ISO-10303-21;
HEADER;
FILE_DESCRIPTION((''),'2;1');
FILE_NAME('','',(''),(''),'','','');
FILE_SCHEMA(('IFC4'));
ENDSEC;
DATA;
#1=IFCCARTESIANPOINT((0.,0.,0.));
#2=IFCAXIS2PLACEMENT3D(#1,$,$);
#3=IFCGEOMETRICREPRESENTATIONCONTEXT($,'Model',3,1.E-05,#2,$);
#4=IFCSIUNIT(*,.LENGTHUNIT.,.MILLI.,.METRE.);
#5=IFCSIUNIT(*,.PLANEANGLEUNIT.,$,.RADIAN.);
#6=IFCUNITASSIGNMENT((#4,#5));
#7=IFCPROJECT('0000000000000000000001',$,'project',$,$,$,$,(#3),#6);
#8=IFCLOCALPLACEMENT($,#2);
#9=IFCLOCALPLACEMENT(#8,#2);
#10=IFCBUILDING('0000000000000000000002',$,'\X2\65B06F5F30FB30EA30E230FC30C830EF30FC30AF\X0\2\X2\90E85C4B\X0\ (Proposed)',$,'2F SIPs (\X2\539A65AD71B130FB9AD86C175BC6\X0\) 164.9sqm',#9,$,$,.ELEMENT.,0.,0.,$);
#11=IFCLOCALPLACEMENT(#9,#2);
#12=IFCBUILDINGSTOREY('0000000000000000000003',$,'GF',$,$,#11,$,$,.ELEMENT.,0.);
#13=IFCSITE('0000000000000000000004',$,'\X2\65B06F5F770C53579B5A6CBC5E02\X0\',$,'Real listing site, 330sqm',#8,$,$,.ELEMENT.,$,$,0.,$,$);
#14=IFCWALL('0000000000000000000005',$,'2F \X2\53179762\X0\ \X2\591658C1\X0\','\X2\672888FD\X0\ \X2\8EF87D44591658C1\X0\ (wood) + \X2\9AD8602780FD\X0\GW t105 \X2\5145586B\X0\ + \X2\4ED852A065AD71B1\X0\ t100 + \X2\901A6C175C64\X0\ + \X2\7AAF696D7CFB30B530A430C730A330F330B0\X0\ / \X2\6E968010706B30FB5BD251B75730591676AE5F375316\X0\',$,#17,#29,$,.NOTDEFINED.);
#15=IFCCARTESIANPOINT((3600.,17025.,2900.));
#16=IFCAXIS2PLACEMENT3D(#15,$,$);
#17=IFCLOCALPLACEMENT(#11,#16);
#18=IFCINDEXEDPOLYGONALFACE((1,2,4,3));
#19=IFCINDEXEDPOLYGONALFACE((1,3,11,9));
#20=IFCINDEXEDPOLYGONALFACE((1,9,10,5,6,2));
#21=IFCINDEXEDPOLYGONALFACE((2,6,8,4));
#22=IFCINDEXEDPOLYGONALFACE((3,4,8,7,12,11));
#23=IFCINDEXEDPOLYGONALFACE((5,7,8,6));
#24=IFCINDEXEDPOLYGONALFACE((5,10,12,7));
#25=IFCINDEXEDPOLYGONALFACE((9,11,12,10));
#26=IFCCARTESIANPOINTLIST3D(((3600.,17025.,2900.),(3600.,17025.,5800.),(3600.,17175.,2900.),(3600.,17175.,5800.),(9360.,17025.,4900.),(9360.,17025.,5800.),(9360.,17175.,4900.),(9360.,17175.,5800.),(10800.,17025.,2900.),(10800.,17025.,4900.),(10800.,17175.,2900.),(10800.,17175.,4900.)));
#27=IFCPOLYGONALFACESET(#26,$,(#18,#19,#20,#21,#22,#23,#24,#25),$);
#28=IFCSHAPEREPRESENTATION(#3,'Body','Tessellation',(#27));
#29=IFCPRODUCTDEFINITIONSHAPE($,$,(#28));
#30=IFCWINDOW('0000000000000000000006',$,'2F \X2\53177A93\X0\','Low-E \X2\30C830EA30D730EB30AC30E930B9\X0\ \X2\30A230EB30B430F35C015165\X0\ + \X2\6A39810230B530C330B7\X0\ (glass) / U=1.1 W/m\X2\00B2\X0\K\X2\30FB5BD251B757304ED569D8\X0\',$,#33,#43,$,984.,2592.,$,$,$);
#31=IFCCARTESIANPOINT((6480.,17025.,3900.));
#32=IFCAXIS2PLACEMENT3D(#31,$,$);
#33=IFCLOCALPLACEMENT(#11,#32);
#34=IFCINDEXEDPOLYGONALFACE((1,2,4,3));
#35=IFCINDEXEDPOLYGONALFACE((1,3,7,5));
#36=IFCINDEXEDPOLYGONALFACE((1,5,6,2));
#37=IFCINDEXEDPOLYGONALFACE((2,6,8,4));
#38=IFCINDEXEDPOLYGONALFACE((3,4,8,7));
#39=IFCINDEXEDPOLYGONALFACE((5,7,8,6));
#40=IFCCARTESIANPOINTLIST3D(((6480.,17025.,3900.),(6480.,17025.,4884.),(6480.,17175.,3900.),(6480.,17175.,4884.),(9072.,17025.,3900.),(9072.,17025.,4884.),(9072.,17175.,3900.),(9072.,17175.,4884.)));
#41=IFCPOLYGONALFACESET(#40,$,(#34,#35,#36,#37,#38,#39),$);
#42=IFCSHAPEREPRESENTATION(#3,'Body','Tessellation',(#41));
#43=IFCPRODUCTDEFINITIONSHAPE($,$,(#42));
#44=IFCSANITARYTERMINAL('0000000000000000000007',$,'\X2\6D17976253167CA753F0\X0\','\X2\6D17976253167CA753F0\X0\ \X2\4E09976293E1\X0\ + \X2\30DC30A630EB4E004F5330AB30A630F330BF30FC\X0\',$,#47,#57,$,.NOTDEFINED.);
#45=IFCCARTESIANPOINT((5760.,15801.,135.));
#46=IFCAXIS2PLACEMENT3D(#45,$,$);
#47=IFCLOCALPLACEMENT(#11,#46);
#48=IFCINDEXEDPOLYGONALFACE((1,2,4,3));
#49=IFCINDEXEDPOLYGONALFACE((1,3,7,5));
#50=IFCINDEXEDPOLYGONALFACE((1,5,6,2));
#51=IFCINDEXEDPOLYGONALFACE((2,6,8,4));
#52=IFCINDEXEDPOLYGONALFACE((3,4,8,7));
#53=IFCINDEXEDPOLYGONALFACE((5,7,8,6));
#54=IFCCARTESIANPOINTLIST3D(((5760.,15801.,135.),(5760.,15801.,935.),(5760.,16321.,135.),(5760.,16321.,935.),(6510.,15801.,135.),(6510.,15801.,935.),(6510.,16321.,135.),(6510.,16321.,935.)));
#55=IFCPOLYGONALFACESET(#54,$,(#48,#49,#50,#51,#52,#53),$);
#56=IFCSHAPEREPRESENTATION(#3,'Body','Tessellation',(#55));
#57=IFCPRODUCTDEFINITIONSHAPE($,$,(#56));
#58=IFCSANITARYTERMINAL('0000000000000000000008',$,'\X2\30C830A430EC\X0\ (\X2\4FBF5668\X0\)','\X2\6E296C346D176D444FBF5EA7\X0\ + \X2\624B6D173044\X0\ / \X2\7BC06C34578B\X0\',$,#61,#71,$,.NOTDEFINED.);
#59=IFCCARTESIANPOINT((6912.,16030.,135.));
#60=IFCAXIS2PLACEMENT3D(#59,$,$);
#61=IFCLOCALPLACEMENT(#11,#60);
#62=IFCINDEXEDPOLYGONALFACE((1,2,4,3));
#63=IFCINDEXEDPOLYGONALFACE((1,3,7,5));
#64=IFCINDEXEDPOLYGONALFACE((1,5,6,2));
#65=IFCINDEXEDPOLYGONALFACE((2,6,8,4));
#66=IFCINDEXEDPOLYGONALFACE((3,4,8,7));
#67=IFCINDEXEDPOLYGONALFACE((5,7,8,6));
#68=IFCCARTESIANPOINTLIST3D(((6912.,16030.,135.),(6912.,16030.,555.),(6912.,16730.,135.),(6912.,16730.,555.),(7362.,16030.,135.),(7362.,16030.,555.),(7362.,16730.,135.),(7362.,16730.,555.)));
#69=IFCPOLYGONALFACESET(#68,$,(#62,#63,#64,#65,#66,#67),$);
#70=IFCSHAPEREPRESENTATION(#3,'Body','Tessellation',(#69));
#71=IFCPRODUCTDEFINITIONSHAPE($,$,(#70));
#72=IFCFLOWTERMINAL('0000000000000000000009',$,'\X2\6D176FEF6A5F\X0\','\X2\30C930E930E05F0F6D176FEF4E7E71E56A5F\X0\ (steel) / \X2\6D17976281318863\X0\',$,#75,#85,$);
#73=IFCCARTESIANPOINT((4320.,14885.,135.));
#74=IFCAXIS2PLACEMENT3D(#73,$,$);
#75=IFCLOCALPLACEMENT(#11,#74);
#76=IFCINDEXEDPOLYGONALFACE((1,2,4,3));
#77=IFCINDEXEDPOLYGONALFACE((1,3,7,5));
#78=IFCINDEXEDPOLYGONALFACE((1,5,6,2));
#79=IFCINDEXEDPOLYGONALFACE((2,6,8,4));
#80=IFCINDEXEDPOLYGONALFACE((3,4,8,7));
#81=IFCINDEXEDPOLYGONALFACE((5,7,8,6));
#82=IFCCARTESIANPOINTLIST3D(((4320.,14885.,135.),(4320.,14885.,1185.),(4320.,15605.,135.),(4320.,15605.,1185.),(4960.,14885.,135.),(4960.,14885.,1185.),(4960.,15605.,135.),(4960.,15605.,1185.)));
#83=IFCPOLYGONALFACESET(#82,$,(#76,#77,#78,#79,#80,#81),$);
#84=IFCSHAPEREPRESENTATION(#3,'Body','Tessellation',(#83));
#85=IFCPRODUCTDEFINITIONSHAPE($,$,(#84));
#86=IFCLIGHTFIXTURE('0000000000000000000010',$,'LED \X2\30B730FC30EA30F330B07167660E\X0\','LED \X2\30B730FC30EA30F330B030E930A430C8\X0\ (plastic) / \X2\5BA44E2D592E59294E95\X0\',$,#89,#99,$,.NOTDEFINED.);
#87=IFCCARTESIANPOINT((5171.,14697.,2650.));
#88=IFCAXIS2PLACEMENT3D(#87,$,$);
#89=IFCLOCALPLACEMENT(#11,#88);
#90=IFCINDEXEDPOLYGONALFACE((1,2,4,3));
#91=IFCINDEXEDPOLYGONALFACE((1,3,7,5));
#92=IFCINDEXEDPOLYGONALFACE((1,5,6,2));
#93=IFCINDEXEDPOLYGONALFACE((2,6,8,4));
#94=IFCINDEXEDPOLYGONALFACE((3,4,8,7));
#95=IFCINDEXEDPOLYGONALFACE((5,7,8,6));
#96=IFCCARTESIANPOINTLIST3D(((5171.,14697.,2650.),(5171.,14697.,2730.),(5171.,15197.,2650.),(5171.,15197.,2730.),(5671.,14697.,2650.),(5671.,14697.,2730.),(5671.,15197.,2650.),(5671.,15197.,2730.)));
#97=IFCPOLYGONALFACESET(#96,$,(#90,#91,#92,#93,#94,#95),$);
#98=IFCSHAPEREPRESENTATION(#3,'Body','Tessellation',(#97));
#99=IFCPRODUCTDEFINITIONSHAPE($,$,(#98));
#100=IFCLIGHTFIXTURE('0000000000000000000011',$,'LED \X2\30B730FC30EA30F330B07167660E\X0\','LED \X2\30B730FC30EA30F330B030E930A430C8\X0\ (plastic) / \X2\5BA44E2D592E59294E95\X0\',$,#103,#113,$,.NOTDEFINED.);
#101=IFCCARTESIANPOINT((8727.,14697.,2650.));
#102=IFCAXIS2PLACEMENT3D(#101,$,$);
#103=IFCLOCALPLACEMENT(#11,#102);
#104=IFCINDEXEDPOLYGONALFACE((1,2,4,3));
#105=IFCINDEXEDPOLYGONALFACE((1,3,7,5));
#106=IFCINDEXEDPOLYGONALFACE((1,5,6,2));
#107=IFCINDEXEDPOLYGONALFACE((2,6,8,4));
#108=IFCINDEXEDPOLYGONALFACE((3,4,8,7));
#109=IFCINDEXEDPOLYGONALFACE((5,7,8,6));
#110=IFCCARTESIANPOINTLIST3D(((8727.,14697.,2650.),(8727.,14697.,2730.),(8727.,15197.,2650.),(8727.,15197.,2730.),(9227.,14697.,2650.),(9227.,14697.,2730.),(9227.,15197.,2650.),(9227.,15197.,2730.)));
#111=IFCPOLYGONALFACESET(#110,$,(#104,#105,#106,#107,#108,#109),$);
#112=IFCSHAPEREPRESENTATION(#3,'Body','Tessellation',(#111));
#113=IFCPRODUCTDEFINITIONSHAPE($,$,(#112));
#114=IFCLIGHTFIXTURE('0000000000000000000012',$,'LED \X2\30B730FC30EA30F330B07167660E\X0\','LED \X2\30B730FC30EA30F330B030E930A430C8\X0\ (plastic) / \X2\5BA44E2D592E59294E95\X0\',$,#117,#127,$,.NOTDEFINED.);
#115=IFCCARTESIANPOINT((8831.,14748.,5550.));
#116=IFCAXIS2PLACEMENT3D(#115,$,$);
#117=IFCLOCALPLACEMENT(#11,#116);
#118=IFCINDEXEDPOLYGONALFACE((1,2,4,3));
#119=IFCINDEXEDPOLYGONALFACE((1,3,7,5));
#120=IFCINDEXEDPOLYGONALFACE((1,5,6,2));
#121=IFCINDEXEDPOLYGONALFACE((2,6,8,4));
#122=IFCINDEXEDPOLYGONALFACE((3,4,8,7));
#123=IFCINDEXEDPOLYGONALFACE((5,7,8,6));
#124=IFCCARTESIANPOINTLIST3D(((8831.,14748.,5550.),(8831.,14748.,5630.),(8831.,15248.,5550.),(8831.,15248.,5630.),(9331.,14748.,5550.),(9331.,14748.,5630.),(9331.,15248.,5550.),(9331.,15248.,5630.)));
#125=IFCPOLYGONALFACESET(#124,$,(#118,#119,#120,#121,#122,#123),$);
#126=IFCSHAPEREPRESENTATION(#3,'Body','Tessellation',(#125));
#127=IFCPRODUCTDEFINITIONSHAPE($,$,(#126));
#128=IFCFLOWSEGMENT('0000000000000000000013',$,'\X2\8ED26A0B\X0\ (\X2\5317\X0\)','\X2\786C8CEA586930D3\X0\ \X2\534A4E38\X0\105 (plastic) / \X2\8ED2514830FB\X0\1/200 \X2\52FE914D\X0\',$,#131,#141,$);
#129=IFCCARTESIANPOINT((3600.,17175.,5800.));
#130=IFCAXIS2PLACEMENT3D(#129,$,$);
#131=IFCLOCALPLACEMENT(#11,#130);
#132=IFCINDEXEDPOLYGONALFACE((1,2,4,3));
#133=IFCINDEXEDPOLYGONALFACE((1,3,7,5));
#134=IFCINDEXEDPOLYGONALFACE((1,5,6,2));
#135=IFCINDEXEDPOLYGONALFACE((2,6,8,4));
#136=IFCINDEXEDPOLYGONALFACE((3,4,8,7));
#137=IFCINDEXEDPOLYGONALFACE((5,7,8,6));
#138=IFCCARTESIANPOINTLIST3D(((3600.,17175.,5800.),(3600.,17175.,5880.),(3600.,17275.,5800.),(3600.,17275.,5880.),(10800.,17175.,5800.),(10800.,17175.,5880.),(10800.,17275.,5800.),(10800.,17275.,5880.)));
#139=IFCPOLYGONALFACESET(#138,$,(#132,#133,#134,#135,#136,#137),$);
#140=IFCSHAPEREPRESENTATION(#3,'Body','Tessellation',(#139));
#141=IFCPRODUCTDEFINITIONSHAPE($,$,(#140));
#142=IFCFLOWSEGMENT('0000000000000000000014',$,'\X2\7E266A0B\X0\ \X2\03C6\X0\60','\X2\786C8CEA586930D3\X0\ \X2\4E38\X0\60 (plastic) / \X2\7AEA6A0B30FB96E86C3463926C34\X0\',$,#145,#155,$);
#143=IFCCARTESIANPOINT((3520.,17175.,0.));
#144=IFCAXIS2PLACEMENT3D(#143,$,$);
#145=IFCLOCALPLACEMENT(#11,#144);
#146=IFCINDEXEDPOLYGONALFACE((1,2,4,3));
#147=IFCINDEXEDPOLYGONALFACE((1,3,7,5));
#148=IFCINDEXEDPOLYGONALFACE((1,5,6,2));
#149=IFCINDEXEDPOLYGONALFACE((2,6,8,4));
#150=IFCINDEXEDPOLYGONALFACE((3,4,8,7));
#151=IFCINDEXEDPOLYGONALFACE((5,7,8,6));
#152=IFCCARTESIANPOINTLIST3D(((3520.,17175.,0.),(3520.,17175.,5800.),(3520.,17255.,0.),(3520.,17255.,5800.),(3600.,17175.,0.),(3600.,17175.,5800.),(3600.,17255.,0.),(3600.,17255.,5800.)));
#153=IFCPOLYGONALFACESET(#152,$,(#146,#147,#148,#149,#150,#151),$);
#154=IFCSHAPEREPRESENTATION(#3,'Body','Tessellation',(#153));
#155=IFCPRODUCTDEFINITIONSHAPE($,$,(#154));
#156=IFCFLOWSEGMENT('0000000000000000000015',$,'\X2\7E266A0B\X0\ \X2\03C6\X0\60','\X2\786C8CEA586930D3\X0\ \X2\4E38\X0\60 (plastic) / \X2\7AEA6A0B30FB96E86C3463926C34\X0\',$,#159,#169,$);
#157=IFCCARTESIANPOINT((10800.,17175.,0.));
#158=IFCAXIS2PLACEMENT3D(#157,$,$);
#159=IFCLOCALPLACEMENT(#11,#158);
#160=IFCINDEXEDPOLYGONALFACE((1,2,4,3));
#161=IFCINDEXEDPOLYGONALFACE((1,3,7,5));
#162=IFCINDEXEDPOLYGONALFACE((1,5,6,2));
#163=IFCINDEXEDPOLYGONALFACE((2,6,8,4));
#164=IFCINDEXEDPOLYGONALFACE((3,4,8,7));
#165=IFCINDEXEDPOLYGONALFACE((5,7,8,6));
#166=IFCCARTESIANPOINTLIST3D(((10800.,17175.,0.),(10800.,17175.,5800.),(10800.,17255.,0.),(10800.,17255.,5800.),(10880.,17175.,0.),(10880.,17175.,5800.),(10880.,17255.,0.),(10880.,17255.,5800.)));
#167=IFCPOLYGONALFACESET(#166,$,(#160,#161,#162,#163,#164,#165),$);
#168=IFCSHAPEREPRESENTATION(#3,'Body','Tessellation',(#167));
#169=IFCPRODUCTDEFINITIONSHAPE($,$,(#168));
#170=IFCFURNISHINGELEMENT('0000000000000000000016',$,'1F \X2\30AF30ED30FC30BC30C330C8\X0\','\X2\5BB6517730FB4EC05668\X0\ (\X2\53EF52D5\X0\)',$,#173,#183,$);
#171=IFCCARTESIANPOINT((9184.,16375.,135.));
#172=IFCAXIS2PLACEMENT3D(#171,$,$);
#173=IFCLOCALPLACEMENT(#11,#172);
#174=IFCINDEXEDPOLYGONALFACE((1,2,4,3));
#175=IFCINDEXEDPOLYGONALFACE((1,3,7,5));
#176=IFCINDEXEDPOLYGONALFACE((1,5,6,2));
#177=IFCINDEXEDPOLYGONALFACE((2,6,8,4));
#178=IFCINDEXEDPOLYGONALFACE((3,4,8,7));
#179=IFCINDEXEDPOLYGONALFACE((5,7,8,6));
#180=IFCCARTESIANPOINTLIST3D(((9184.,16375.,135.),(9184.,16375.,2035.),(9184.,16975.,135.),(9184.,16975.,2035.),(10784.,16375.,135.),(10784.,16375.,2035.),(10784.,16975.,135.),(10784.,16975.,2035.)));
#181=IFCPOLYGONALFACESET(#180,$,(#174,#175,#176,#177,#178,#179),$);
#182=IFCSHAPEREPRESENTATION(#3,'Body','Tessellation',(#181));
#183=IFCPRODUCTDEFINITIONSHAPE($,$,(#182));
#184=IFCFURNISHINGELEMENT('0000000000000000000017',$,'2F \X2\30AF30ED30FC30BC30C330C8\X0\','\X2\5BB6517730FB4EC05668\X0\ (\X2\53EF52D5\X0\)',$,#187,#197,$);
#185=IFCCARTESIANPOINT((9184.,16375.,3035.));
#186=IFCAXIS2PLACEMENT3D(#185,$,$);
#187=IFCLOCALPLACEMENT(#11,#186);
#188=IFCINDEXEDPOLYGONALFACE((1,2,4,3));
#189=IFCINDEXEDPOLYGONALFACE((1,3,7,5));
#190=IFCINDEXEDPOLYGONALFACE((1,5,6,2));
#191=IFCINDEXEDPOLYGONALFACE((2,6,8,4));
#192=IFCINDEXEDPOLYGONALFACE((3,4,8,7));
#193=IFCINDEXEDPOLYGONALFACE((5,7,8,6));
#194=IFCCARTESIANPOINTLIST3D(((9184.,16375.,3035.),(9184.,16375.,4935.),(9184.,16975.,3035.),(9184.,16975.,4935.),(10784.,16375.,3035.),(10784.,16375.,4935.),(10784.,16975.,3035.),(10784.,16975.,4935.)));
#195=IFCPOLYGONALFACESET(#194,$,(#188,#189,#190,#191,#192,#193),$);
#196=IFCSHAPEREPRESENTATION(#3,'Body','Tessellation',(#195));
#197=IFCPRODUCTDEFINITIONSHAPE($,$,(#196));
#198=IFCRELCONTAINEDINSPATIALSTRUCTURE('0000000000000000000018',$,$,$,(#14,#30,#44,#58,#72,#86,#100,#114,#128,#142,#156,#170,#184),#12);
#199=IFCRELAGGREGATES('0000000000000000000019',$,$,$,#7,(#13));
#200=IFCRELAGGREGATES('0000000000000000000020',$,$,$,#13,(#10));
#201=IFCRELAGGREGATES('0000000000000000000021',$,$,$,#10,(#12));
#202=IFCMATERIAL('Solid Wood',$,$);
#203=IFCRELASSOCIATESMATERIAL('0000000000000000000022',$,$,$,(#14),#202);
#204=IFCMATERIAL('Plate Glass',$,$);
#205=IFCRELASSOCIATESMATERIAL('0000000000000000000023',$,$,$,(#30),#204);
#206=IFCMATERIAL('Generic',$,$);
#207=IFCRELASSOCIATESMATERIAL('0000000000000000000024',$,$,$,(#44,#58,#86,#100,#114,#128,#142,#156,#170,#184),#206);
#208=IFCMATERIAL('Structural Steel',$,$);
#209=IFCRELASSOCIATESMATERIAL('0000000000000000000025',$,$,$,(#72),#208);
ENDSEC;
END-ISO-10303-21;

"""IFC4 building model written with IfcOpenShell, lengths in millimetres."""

from ifc_helpers import new_model, si_unit, frame, frame_2d, origin, place, context, project, spatial, rectangle, extrude, material, element, fill, save


model = new_model("IFC4")

# Units and contexts
model_context = context("Model", 3, precision=1e-05, world=origin())
ifc_project = project(units=[si_unit("LENGTHUNIT", "METRE", prefix="MILLI"), si_unit("PLANEANGLEUNIT", "RADIAN")], contexts=[model_context])

# Site, building, storey
site_placement = place(None, origin())
site = spatial("IfcSite", under=ifc_project, at=site_placement, Name="新潟県南魚沼市", ObjectType="Real listing site, 330sqm", CompositionType="ELEMENT", RefElevation=0.0)
building_placement = place(site_placement, origin())
building = spatial("IfcBuilding", under=site, at=building_placement, Name="新潟・リモートワーク2部屋 (Proposed)", ObjectType="2F SIPs (厚断熱・高気密) 164.9sqm", CompositionType="ELEMENT", ElevationOfRefHeight=0.0, ElevationOfTerrain=0.0)
storey_placement = place(building_placement, origin())
storey = spatial("IfcBuildingStorey", under=building, at=storey_placement, Name="GF", CompositionType="ELEMENT", Elevation=0.0)

# Shared definitions
ifc_material_1 = material(Name="Solid Wood")

# Shared definitions
ifc_material_2 = material(Name="Plate Glass")

# Wall, opening, window
wall_1_placement = place(storey_placement, frame((3600.0, 17025.0, 2900.0)))
wall_1 = element("IfcWall", 1, at=wall_1_placement, inside=storey, material=ifc_material_1, Name="2F 北面 外壁", Description="木製 軸組外壁 (wood) + 高性能GW t105 充填 + 付加断熱 t100 + 通気層 + 窯業系サイディング / 準耐火・寒冷地外皮強化", PredefinedType="NOTDEFINED", context=model_context, shape_type="SweptSolid", body=[
    extrude(rectangle(XDim=7200.0, YDim=150.0, at=frame_2d((3600.0, 75.0))), frame((3600.0, 17025.0, 2900.0)), (0.0, 0.0, 1.0), 2900.0),
])
opening_1_placement = place(storey_placement, frame((6480.0, 17025.0, 3900.0)))
opening_1 = element("IfcOpeningElement", 2, at=opening_1_placement, cuts=wall_1, PredefinedType="NOTDEFINED", context=model_context, shape_type="SweptSolid", body=[
    extrude(rectangle(XDim=2592.0, YDim=150.0, at=frame_2d((1296.0, 75.0))), frame((6480.0, 17025.0, 3900.0)), (0.0, 0.0, 1.0), 984.0),
])
window_1_placement = place(storey_placement, frame((6480.0, 17025.0, 3900.0)))
window_1 = element("IfcWindow", 3, at=window_1_placement, inside=storey, material=ifc_material_2, Name="2F 北窓", Description="Low-E トリプルガラス アルゴン封入 + 樹脂サッシ (glass) / U=1.1 W/m²K・寒冷地仕様", OverallHeight=984.0, OverallWidth=2592.0, context=model_context, shape_type="SweptSolid", body=[
    extrude(rectangle(XDim=2592.0, YDim=150.0, at=frame_2d((1296.0, 75.0))), frame((6480.0, 17025.0, 3900.0)), (0.0, 0.0, 1.0), 984.0),
])
fill(opening_1, window_1)

# Sanitary terminals
ifc_material_3 = material(Name="Generic")
sanitary_terminal_1_placement = place(storey_placement, frame((5760.0, 15801.0, 135.0)))
element("IfcSanitaryTerminal", 4, at=sanitary_terminal_1_placement, inside=storey, material=ifc_material_3, Name="洗面化粧台", Description="洗面化粧台 三面鏡 + ボウル一体カウンター", PredefinedType="NOTDEFINED", context=model_context, shape_type="SweptSolid", body=[
    extrude(rectangle(XDim=750.0, YDim=520.0, at=frame_2d((375.0, 260.0))), frame((5760.0, 15801.0, 135.0)), (0.0, 0.0, 1.0), 800.0),
])
sanitary_terminal_2_placement = place(storey_placement, frame((6912.0, 16030.0, 135.0)))
element("IfcSanitaryTerminal", 5, at=sanitary_terminal_2_placement, inside=storey, material=ifc_material_3, Name="トイレ (便器)", Description="温水洗浄便座 + 手洗い / 節水型", PredefinedType="NOTDEFINED", context=model_context, shape_type="SweptSolid", body=[
    extrude(rectangle(XDim=450.0, YDim=700.0, at=frame_2d((225.0, 350.0))), frame((6912.0, 16030.0, 135.0)), (0.0, 0.0, 1.0), 420.0),
])

# Flow terminal
ifc_material_4 = material(Name="Structural Steel")
flow_terminal_placement = place(storey_placement, frame((4320.0, 14885.0, 135.0)))
element("IfcFlowTerminal", 6, at=flow_terminal_placement, inside=storey, material=ifc_material_4, Name="洗濯機", Description="ドラム式洗濯乾燥機 (steel) / 洗面脱衣", context=model_context, shape_type="SweptSolid", body=[
    extrude(rectangle(XDim=640.0, YDim=720.0, at=frame_2d((320.0, 360.0))), frame((4320.0, 14885.0, 135.0)), (0.0, 0.0, 1.0), 1050.0),
])

# Light fixtures
light_fixture_1_placement = place(storey_placement, frame((5171.0, 14697.0, 2650.0)))
element("IfcLightFixture", 7, at=light_fixture_1_placement, inside=storey, material=ifc_material_3, Name="LED シーリング照明", Description="LED シーリングライト (plastic) / 室中央天井", PredefinedType="NOTDEFINED", context=model_context, shape_type="SweptSolid", body=[
    extrude(rectangle(XDim=500.0, YDim=500.0, at=frame_2d((250.0, 250.0))), frame((5171.0, 14697.0, 2650.0)), (0.0, 0.0, 1.0), 80.0),
])
light_fixture_2_placement = place(storey_placement, frame((8727.0, 14697.0, 2650.0)))
element("IfcLightFixture", 8, at=light_fixture_2_placement, inside=storey, material=ifc_material_3, Name="LED シーリング照明", Description="LED シーリングライト (plastic) / 室中央天井", PredefinedType="NOTDEFINED", context=model_context, shape_type="SweptSolid", body=[
    extrude(rectangle(XDim=500.0, YDim=500.0, at=frame_2d((250.0, 250.0))), frame((8727.0, 14697.0, 2650.0)), (0.0, 0.0, 1.0), 80.0),
])
light_fixture_3_placement = place(storey_placement, frame((8831.0, 14748.0, 5550.0)))
element("IfcLightFixture", 9, at=light_fixture_3_placement, inside=storey, material=ifc_material_3, Name="LED シーリング照明", Description="LED シーリングライト (plastic) / 室中央天井", PredefinedType="NOTDEFINED", context=model_context, shape_type="SweptSolid", body=[
    extrude(rectangle(XDim=500.0, YDim=500.0, at=frame_2d((250.0, 250.0))), frame((8831.0, 14748.0, 5550.0)), (0.0, 0.0, 1.0), 80.0),
])

# Flow segments
flow_segment_1_placement = place(storey_placement, frame((3600.0, 17175.0, 5800.0)))
element("IfcFlowSegment", 10, at=flow_segment_1_placement, inside=storey, material=ifc_material_3, Name="軒樋 (北)", Description="硬質塩ビ 半丸105 (plastic) / 軒先・1/200 勾配", context=model_context, shape_type="SweptSolid", body=[
    extrude(rectangle(XDim=7200.0, YDim=100.0, at=frame_2d((3600.0, 50.0))), frame((3600.0, 17175.0, 5800.0)), (0.0, 0.0, 1.0), 80.0),
])
flow_segment_2_placement = place(storey_placement, frame((3520.0, 17175.0, 0.0)))
element("IfcFlowSegment", 11, at=flow_segment_2_placement, inside=storey, material=ifc_material_3, Name="縦樋 φ60", Description="硬質塩ビ 丸60 (plastic) / 竪樋・雨水排水", context=model_context, shape_type="SweptSolid", body=[
    extrude(rectangle(XDim=80.0, YDim=80.0, at=frame_2d((40.0, 40.0))), frame((3520.0, 17175.0, 0.0)), (0.0, 0.0, 1.0), 5800.0),
])
flow_segment_3_placement = place(storey_placement, frame((10800.0, 17175.0, 0.0)))
element("IfcFlowSegment", 12, at=flow_segment_3_placement, inside=storey, material=ifc_material_3, Name="縦樋 φ60", Description="硬質塩ビ 丸60 (plastic) / 竪樋・雨水排水", context=model_context, shape_type="SweptSolid", body=[
    extrude(rectangle(XDim=80.0, YDim=80.0, at=frame_2d((40.0, 40.0))), frame((10800.0, 17175.0, 0.0)), (0.0, 0.0, 1.0), 5800.0),
])

# Furnishing elements
furnishing_1_placement = place(storey_placement, frame((9184.0, 16375.0, 135.0)))
element("IfcFurnishingElement", 13, at=furnishing_1_placement, inside=storey, material=ifc_material_3, Name="1F クローゼット", Description="家具・什器 (可動)", context=model_context, shape_type="SweptSolid", body=[
    extrude(rectangle(XDim=1600.0, YDim=600.0, at=frame_2d((800.0, 300.0))), frame((9184.0, 16375.0, 135.0)), (0.0, 0.0, 1.0), 1900.0),
])
furnishing_2_placement = place(storey_placement, frame((9184.0, 16375.0, 3035.0)))
element("IfcFurnishingElement", 14, at=furnishing_2_placement, inside=storey, material=ifc_material_3, Name="2F クローゼット", Description="家具・什器 (可動)", context=model_context, shape_type="SweptSolid", body=[
    extrude(rectangle(XDim=1600.0, YDim=600.0, at=frame_2d((800.0, 300.0))), frame((9184.0, 16375.0, 3035.0)), (0.0, 0.0, 1.0), 1900.0),
])

save(model, "model.ifc")
